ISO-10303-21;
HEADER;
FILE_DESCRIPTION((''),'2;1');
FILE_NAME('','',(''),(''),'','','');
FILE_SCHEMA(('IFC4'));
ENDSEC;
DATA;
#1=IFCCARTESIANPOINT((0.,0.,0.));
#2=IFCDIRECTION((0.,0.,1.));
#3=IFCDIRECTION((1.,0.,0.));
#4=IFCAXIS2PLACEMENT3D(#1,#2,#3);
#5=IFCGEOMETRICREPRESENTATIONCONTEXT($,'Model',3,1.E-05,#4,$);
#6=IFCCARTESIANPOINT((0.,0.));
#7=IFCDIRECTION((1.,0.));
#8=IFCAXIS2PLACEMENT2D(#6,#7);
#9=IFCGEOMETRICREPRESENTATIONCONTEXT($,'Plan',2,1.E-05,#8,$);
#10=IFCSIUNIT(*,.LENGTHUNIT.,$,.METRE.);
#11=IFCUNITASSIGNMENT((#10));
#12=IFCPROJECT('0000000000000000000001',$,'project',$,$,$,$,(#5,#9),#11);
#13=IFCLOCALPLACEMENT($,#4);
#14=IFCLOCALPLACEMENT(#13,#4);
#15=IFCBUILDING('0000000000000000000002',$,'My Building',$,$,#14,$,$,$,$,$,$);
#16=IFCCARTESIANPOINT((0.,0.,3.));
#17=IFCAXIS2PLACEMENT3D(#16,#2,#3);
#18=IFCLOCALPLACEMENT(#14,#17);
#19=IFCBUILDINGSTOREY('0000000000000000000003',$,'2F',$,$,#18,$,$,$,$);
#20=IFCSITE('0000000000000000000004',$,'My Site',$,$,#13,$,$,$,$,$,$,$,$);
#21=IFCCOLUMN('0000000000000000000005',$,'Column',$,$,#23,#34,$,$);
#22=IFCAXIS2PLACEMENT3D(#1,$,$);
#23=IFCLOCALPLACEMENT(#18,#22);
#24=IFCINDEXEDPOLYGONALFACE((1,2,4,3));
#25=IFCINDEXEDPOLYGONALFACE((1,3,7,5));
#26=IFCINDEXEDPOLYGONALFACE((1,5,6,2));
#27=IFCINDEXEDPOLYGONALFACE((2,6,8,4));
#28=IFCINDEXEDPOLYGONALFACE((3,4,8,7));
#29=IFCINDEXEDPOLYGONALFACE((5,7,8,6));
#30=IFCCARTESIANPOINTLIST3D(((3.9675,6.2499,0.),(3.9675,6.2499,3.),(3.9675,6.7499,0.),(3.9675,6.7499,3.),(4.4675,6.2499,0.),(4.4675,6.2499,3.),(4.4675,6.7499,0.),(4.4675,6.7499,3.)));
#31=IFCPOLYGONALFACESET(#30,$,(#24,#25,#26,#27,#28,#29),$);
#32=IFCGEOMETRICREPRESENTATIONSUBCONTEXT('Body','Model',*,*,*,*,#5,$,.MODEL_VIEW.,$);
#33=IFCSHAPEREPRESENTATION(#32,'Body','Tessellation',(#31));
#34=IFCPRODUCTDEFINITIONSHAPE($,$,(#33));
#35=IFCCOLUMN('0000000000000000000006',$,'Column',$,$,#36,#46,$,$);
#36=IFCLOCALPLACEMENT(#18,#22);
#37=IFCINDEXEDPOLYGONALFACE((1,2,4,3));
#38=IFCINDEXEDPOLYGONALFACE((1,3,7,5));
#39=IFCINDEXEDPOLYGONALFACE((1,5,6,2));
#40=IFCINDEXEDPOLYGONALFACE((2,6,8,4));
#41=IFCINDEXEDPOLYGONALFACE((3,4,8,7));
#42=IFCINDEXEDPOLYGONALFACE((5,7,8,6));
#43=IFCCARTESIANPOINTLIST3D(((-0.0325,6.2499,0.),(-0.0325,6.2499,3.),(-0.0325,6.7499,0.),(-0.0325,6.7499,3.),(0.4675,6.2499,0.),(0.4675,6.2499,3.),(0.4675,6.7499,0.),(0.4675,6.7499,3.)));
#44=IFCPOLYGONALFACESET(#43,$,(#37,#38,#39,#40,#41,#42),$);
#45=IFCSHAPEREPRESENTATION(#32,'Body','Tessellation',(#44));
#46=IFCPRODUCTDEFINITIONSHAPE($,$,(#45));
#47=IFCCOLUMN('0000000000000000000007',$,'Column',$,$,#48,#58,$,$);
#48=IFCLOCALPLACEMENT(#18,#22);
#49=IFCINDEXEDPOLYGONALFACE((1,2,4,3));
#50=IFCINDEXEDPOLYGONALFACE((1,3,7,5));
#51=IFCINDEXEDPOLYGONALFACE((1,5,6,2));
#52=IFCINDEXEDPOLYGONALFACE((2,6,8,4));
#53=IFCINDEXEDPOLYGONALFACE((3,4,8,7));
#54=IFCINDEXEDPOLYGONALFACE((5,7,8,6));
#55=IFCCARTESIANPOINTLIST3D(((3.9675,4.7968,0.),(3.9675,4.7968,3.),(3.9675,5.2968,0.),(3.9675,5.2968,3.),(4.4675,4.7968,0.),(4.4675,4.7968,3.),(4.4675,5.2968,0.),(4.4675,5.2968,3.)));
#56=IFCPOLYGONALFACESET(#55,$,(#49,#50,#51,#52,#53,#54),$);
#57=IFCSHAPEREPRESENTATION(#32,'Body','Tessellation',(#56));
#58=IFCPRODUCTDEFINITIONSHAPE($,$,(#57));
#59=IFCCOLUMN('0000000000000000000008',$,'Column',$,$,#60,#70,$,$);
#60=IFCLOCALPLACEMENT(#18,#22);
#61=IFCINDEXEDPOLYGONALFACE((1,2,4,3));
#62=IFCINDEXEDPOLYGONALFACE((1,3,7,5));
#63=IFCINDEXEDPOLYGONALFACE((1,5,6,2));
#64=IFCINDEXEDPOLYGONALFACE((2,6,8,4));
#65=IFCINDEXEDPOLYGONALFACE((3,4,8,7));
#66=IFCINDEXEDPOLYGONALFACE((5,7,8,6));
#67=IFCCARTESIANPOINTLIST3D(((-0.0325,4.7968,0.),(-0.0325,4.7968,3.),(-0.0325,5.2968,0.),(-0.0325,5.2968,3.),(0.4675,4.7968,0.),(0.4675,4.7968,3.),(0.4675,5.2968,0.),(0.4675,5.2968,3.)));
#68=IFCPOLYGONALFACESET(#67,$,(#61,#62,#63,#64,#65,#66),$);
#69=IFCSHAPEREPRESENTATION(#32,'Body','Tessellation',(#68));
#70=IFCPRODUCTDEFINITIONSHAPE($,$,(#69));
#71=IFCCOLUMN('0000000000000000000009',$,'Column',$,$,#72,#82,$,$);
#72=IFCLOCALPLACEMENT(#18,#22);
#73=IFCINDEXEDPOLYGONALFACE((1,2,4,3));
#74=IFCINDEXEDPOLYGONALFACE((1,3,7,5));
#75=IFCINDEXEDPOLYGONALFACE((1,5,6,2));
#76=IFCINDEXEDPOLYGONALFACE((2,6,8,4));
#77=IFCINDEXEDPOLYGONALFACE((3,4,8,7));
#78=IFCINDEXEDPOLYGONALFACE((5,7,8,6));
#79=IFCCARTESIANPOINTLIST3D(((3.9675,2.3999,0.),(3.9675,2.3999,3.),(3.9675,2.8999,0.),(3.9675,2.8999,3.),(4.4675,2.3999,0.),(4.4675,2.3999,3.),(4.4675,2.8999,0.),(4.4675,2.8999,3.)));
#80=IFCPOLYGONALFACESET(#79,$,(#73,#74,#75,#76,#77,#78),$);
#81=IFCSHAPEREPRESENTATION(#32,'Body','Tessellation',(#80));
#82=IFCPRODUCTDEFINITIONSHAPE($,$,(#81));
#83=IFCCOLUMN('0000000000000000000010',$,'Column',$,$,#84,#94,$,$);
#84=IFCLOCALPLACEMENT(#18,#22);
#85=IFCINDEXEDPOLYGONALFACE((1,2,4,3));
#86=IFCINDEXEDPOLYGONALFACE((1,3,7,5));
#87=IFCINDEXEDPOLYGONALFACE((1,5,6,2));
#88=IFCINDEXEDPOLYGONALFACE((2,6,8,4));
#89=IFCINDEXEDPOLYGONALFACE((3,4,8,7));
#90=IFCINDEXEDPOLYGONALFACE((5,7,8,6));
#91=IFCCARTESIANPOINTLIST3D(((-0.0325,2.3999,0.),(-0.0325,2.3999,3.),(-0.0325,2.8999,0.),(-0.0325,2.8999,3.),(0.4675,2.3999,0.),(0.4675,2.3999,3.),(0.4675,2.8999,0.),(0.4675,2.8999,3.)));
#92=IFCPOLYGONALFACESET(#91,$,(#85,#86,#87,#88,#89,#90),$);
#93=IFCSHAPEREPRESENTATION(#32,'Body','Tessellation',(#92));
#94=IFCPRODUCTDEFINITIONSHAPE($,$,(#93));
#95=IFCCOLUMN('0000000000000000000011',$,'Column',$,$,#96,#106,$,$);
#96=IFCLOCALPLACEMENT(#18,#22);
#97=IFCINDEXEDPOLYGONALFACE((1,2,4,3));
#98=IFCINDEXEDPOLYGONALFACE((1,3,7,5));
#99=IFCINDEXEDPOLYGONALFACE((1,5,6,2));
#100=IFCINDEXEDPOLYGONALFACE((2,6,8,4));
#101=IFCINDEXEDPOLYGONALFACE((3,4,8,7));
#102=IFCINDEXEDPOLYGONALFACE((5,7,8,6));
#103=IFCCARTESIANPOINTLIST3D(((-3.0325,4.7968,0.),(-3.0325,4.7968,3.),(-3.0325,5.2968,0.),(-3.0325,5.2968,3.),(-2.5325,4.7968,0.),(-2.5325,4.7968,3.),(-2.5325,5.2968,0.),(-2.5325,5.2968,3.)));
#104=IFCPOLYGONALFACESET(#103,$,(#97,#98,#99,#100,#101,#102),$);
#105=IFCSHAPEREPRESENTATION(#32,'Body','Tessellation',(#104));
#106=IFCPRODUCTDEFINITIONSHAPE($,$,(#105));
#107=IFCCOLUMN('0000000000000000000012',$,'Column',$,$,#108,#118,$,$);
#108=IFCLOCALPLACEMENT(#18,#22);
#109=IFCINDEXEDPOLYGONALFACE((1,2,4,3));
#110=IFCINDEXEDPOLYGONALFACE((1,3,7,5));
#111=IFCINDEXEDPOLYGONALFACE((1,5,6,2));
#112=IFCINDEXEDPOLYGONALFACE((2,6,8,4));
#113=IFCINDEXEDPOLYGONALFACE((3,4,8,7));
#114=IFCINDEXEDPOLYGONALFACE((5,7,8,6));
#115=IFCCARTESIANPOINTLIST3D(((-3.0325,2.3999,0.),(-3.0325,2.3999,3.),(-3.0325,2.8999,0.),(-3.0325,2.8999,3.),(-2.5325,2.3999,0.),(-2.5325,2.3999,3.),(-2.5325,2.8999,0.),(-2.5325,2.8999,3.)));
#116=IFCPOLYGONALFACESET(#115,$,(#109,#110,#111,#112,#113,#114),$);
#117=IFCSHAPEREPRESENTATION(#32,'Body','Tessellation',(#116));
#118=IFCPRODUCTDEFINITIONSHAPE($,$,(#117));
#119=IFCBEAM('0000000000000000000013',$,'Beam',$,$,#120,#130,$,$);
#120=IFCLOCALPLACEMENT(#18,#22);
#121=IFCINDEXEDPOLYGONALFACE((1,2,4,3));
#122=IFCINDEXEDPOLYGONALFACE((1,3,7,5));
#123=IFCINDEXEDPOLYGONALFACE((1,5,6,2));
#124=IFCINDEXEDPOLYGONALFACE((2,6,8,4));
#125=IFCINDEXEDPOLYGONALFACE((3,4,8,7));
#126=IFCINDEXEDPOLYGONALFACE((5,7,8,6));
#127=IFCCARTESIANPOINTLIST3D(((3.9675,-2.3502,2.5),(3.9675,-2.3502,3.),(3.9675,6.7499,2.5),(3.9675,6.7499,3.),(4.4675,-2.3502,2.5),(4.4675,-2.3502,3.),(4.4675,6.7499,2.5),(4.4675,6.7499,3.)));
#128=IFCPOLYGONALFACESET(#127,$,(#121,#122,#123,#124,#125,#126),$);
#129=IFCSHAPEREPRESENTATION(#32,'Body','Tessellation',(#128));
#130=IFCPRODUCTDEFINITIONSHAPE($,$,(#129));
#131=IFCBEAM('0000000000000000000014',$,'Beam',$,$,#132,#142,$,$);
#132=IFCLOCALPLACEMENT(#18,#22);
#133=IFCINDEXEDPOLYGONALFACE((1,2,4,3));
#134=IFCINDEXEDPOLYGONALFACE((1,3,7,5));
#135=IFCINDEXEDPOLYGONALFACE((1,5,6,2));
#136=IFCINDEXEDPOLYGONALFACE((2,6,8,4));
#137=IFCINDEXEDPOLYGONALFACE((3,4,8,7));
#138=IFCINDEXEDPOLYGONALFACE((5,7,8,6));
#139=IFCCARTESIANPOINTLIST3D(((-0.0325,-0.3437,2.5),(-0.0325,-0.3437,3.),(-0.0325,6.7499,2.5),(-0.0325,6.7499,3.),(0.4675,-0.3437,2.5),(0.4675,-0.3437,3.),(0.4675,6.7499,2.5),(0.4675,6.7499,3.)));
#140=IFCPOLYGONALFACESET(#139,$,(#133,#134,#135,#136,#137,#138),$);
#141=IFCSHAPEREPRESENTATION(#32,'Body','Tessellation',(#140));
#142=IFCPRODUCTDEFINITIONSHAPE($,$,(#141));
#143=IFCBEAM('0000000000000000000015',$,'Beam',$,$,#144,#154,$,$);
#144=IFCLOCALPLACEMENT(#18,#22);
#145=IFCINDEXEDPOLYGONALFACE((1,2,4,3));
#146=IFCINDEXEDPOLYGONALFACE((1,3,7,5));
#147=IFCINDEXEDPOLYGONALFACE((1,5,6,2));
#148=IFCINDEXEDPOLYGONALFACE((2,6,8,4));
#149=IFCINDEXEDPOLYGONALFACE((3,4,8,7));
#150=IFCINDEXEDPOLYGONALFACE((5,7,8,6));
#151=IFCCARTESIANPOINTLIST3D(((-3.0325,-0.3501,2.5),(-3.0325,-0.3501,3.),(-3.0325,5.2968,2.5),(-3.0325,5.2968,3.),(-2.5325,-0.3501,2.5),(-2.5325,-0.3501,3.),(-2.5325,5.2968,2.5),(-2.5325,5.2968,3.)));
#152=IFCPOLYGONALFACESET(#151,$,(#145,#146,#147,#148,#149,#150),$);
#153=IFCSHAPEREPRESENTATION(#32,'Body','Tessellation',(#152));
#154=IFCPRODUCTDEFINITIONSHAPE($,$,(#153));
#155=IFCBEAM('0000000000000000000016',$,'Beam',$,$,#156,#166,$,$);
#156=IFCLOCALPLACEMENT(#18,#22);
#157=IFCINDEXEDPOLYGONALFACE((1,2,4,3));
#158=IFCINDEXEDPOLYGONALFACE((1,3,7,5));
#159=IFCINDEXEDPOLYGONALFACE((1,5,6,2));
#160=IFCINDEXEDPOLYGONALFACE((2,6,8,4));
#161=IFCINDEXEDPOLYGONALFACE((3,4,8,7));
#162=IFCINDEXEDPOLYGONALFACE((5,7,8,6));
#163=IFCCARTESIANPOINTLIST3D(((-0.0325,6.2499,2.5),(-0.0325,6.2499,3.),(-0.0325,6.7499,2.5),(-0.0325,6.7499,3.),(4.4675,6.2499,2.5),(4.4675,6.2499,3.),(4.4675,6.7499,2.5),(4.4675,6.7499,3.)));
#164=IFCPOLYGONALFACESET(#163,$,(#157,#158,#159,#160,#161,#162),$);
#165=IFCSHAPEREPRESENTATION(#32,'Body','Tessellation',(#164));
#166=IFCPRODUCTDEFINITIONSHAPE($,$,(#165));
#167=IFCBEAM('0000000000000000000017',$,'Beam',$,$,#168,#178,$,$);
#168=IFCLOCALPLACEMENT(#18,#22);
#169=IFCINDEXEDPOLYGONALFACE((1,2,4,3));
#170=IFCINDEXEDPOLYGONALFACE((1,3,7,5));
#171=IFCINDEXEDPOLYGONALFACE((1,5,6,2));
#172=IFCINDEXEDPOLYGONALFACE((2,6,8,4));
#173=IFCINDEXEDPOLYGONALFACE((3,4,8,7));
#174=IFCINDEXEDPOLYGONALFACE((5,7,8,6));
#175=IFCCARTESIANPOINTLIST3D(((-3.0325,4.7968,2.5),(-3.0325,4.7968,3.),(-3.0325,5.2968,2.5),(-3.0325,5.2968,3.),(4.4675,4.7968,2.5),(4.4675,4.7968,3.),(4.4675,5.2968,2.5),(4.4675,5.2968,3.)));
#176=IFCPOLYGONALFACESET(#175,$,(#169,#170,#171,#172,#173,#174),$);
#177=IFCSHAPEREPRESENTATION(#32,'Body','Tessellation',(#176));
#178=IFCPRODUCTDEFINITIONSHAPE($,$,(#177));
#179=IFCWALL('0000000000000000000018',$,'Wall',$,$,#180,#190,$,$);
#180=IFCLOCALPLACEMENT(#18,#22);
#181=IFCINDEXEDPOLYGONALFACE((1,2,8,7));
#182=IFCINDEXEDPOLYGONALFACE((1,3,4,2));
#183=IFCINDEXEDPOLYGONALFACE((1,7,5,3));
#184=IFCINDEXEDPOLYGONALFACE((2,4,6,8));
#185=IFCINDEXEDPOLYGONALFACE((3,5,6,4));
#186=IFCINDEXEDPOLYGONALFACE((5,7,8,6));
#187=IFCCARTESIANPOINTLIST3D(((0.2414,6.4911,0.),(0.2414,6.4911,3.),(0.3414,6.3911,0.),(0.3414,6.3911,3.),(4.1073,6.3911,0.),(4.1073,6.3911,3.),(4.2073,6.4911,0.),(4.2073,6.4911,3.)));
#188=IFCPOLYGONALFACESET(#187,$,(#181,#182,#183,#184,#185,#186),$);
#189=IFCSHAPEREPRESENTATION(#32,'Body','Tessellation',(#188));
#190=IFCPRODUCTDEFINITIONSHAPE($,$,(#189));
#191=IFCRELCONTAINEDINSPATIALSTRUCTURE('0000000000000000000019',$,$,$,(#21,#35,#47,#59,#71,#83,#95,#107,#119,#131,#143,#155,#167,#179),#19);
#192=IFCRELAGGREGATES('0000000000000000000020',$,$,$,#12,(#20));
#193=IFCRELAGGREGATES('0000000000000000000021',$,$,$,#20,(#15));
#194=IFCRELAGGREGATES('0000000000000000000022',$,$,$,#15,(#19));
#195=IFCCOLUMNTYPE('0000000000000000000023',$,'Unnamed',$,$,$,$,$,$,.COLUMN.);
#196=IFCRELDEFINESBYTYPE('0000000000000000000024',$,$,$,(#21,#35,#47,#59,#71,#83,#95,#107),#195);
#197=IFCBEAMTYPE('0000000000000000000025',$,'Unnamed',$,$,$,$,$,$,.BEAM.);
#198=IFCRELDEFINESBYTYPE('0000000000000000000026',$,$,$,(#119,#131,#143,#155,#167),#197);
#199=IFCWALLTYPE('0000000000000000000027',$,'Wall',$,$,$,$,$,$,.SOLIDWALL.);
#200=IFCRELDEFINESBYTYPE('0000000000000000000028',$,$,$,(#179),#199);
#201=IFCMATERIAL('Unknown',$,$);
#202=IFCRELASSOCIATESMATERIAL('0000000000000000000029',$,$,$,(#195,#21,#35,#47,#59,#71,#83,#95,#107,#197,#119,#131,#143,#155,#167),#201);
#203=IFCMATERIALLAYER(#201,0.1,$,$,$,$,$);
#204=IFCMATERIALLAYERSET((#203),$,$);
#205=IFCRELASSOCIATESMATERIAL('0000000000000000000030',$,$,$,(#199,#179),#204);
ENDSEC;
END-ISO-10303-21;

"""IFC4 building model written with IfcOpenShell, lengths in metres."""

from ifc_helpers import new_model, si_unit, frame, origin_with_axes, origin_2d_with_axis, place, context, subcontext, project, spatial, line, indexed_curve, rectangle, outline, extrude, material, layer, layer_set, layer_usage, material_profile, profile_set, profile_usage, type_object, element, save


model = new_model("IFC4")

# Units and contexts
model_context = context("Model", 3, precision=1e-05, world=origin_with_axes())
plan_context = context("Plan", 2, precision=1e-05, world=origin_2d_with_axis())
body_context_1 = subcontext(model_context, "Body", "Model", "MODEL_VIEW")
ifc_project = project(units=[si_unit("LENGTHUNIT", "METRE")], contexts=[model_context, plan_context])

# Site, building, storey
site_placement = place(None, origin_with_axes())
site = spatial("IfcSite", under=ifc_project, at=site_placement, Name="My Site")
building_placement = place(site_placement, origin_with_axes())
building = spatial("IfcBuilding", under=site, at=building_placement, Name="My Building")
storey_placement = place(building_placement, frame((0.0, 0.0, 3.0), z_axis=(0.0, 0.0, 1.0), x_axis=(1.0, 0.0, 0.0)))
storey = spatial("IfcBuildingStorey", under=building, at=storey_placement, Name="2F")

# Columns
ifc_material = material(Name="Unknown")
ifc_material_profile_1 = material_profile(ifc_material, rectangle(XDim=0.5, YDim=0.5))
ifc_profile_set_1 = profile_set([ifc_material_profile_1])
ifc_profile_usage_1 = profile_usage(ifc_profile_set_1, cardinal=5)
column_type = type_object("IfcColumnType", Name="Unnamed", PredefinedType="COLUMN", material=ifc_profile_set_1)
column_1_placement = place(storey_placement, frame((4.2175, 6.4999, 0.0), z_axis=(0.0, 0.0, 1.0), x_axis=(1.0, 0.0, 0.0)))
element("IfcColumn", 1, at=column_1_placement, inside=storey, type_object=column_type, material=ifc_profile_usage_1, Name="Column", context=body_context_1, shape_type="SweptSolid", body=[
    extrude(rectangle(XDim=0.5, YDim=0.5), origin_with_axes(), (0.0, 0.0, 1.0), 3.0),
])
ifc_profile_usage_2 = profile_usage(ifc_profile_set_1, cardinal=5)
column_2_placement = place(storey_placement, frame((0.2175, 6.4999, 0.0), z_axis=(0.0, 0.0, 1.0), x_axis=(1.0, 0.0, 0.0)))
element("IfcColumn", 2, at=column_2_placement, inside=storey, type_object=column_type, material=ifc_profile_usage_2, Name="Column", context=body_context_1, shape_type="SweptSolid", body=[
    extrude(rectangle(XDim=0.5, YDim=0.5), origin_with_axes(), (0.0, 0.0, 1.0), 3.0),
])
ifc_profile_usage_3 = profile_usage(ifc_profile_set_1, cardinal=5)
column_3_placement = place(storey_placement, frame((4.2175, 5.0468, 0.0), z_axis=(0.0, 0.0, 1.0), x_axis=(1.0, 0.0, 0.0)))
element("IfcColumn", 3, at=column_3_placement, inside=storey, type_object=column_type, material=ifc_profile_usage_3, Name="Column", context=body_context_1, shape_type="SweptSolid", body=[
    extrude(rectangle(XDim=0.5, YDim=0.5), origin_with_axes(), (0.0, 0.0, 1.0), 3.0),
])
ifc_profile_usage_4 = profile_usage(ifc_profile_set_1, cardinal=5)
column_4_placement = place(storey_placement, frame((0.2175, 5.0468, 0.0), z_axis=(0.0, 0.0, 1.0), x_axis=(1.0, 0.0, 0.0)))
element("IfcColumn", 4, at=column_4_placement, inside=storey, type_object=column_type, material=ifc_profile_usage_4, Name="Column", context=body_context_1, shape_type="SweptSolid", body=[
    extrude(rectangle(XDim=0.5, YDim=0.5), origin_with_axes(), (0.0, 0.0, 1.0), 3.0),
])
ifc_profile_usage_5 = profile_usage(ifc_profile_set_1, cardinal=5)
column_5_placement = place(storey_placement, frame((4.2175, 2.6499, 0.0), z_axis=(0.0, 0.0, 1.0), x_axis=(1.0, 0.0, 0.0)))
element("IfcColumn", 5, at=column_5_placement, inside=storey, type_object=column_type, material=ifc_profile_usage_5, Name="Column", context=body_context_1, shape_type="SweptSolid", body=[
    extrude(rectangle(XDim=0.5, YDim=0.5), origin_with_axes(), (0.0, 0.0, 1.0), 3.0),
])
ifc_profile_usage_6 = profile_usage(ifc_profile_set_1, cardinal=5)
column_6_placement = place(storey_placement, frame((0.2175, 2.6499, 0.0), z_axis=(0.0, 0.0, 1.0), x_axis=(1.0, 0.0, 0.0)))
element("IfcColumn", 6, at=column_6_placement, inside=storey, type_object=column_type, material=ifc_profile_usage_6, Name="Column", context=body_context_1, shape_type="SweptSolid", body=[
    extrude(rectangle(XDim=0.5, YDim=0.5), origin_with_axes(), (0.0, 0.0, 1.0), 3.0),
])
ifc_profile_usage_7 = profile_usage(ifc_profile_set_1, cardinal=5)
column_7_placement = place(storey_placement, frame((-2.7825, 5.0468, 0.0), z_axis=(0.0, 0.0, 1.0), x_axis=(1.0, 0.0, 0.0)))
element("IfcColumn", 7, at=column_7_placement, inside=storey, type_object=column_type, material=ifc_profile_usage_7, Name="Column", context=body_context_1, shape_type="SweptSolid", body=[
    extrude(rectangle(XDim=0.5, YDim=0.5), origin_with_axes(), (0.0, 0.0, 1.0), 3.0),
])
ifc_profile_usage_8 = profile_usage(ifc_profile_set_1, cardinal=5)
column_8_placement = place(storey_placement, frame((-2.7825, 2.6499, 0.0), z_axis=(0.0, 0.0, 1.0), x_axis=(1.0, 0.0, 0.0)))
element("IfcColumn", 8, at=column_8_placement, inside=storey, type_object=column_type, material=ifc_profile_usage_8, Name="Column", context=body_context_1, shape_type="SweptSolid", body=[
    extrude(rectangle(XDim=0.5, YDim=0.5), origin_with_axes(), (0.0, 0.0, 1.0), 3.0),
])

# Beams
ifc_material_profile_2 = material_profile(ifc_material, rectangle(XDim=0.5, YDim=0.5))
ifc_profile_set_2 = profile_set([ifc_material_profile_2])
ifc_profile_usage_9 = profile_usage(ifc_profile_set_2, cardinal=7)
beam_type = type_object("IfcBeamType", Name="Unnamed", PredefinedType="BEAM", material=ifc_profile_set_2)
beam_1_placement = place(storey_placement, frame((4.4675, 6.7499, 3.0), z_axis=(0.0, -1.0, 0.0), x_axis=(1.0, 0.0, 0.0)))
element("IfcBeam", 9, at=beam_1_placement, inside=storey, type_object=beam_type, material=ifc_profile_usage_9, Name="Beam", context=body_context_1, shape_type="SweptSolid", body=[
    extrude(rectangle(XDim=0.5, YDim=0.5), frame((-0.25, -0.25, 0.0), z_axis=(0.0, 0.0, 1.0), x_axis=(1.0, 0.0, 0.0)), (0.0, 0.0, 1.0), 9.1001),
])
ifc_profile_usage_10 = profile_usage(ifc_profile_set_2, cardinal=7)
beam_2_placement = place(storey_placement, frame((0.4675, 6.7499, 3.0), z_axis=(0.0, -1.0, 0.0), x_axis=(1.0, 0.0, 0.0)))
element("IfcBeam", 10, at=beam_2_placement, inside=storey, type_object=beam_type, material=ifc_profile_usage_10, Name="Beam", context=body_context_1, shape_type="SweptSolid", body=[
    extrude(rectangle(XDim=0.5, YDim=0.5), frame((-0.25, -0.25, 0.0), z_axis=(0.0, 0.0, 1.0), x_axis=(1.0, 0.0, 0.0)), (0.0, 0.0, 1.0), 7.0937),
])
ifc_profile_usage_11 = profile_usage(ifc_profile_set_2, cardinal=7)
beam_3_placement = place(storey_placement, frame((-2.5325, 5.2968, 3.0), z_axis=(0.0, -1.0, 0.0), x_axis=(1.0, 0.0, 0.0)))
element("IfcBeam", 11, at=beam_3_placement, inside=storey, type_object=beam_type, material=ifc_profile_usage_11, Name="Beam", context=body_context_1, shape_type="SweptSolid", body=[
    extrude(rectangle(XDim=0.5, YDim=0.5), frame((-0.25, -0.25, 0.0), z_axis=(0.0, 0.0, 1.0), x_axis=(1.0, 0.0, 0.0)), (0.0, 0.0, 1.0), 5.6469),
])
ifc_profile_usage_12 = profile_usage(ifc_profile_set_2, cardinal=7)
beam_4_placement = place(storey_placement, frame((4.4675, 6.2499, 3.0), z_axis=(-1.0, 0.0, 0.0), x_axis=(0.0, -1.0, 0.0)))
element("IfcBeam", 12, at=beam_4_placement, inside=storey, type_object=beam_type, material=ifc_profile_usage_12, Name="Beam", context=body_context_1, shape_type="SweptSolid", body=[
    extrude(rectangle(XDim=0.5, YDim=0.5), frame((-0.25, -0.25, 0.0), z_axis=(0.0, 0.0, 1.0), x_axis=(1.0, 0.0, 0.0)), (0.0, 0.0, 1.0), 4.5),
])
ifc_profile_usage_13 = profile_usage(ifc_profile_set_2, cardinal=7)
beam_5_placement = place(storey_placement, frame((4.4675, 4.7968, 3.0), z_axis=(-1.0, 0.0, 0.0), x_axis=(0.0, -1.0, 0.0)))
element("IfcBeam", 13, at=beam_5_placement, inside=storey, type_object=beam_type, material=ifc_profile_usage_13, Name="Beam", context=body_context_1, shape_type="SweptSolid", body=[
    extrude(rectangle(XDim=0.5, YDim=0.5), frame((-0.25, -0.25, 0.0), z_axis=(0.0, 0.0, 1.0), x_axis=(1.0, 0.0, 0.0)), (0.0, 0.0, 1.0), 7.5),
])

# Wall
ifc_layer = layer(ifc_material, 0.1)
ifc_layer_set = layer_set([ifc_layer])
ifc_layer_usage_1 = layer_usage(ifc_layer_set, "AXIS2", "POSITIVE", 0.0)
wall_type = type_object("IfcWallType", Name="Wall", PredefinedType="SOLIDWALL", material=ifc_layer_set)
wall_1_placement = place(storey_placement, frame((4.2073, 6.4911, 0.0), z_axis=(0.0, 0.0, 1.0), x_axis=(-1.0, 0.0, 0.0)))
element("IfcWall", 14, at=wall_1_placement, inside=storey, type_object=wall_type, material=ifc_layer_usage_1, Name="Wall", context=body_context_1, shape_type="SweptSolid", body=[
    extrude(outline(indexed_curve([(0.0, 0.0), (0.1, 0.1), (3.8658, 0.1), (3.9658, 0.0)], segments=[line(1, 2, 3, 4, 1)])), origin_with_axes(), (0.0, 0.0, 1.0), 3.0),
])

save(model, "model.ifc")
